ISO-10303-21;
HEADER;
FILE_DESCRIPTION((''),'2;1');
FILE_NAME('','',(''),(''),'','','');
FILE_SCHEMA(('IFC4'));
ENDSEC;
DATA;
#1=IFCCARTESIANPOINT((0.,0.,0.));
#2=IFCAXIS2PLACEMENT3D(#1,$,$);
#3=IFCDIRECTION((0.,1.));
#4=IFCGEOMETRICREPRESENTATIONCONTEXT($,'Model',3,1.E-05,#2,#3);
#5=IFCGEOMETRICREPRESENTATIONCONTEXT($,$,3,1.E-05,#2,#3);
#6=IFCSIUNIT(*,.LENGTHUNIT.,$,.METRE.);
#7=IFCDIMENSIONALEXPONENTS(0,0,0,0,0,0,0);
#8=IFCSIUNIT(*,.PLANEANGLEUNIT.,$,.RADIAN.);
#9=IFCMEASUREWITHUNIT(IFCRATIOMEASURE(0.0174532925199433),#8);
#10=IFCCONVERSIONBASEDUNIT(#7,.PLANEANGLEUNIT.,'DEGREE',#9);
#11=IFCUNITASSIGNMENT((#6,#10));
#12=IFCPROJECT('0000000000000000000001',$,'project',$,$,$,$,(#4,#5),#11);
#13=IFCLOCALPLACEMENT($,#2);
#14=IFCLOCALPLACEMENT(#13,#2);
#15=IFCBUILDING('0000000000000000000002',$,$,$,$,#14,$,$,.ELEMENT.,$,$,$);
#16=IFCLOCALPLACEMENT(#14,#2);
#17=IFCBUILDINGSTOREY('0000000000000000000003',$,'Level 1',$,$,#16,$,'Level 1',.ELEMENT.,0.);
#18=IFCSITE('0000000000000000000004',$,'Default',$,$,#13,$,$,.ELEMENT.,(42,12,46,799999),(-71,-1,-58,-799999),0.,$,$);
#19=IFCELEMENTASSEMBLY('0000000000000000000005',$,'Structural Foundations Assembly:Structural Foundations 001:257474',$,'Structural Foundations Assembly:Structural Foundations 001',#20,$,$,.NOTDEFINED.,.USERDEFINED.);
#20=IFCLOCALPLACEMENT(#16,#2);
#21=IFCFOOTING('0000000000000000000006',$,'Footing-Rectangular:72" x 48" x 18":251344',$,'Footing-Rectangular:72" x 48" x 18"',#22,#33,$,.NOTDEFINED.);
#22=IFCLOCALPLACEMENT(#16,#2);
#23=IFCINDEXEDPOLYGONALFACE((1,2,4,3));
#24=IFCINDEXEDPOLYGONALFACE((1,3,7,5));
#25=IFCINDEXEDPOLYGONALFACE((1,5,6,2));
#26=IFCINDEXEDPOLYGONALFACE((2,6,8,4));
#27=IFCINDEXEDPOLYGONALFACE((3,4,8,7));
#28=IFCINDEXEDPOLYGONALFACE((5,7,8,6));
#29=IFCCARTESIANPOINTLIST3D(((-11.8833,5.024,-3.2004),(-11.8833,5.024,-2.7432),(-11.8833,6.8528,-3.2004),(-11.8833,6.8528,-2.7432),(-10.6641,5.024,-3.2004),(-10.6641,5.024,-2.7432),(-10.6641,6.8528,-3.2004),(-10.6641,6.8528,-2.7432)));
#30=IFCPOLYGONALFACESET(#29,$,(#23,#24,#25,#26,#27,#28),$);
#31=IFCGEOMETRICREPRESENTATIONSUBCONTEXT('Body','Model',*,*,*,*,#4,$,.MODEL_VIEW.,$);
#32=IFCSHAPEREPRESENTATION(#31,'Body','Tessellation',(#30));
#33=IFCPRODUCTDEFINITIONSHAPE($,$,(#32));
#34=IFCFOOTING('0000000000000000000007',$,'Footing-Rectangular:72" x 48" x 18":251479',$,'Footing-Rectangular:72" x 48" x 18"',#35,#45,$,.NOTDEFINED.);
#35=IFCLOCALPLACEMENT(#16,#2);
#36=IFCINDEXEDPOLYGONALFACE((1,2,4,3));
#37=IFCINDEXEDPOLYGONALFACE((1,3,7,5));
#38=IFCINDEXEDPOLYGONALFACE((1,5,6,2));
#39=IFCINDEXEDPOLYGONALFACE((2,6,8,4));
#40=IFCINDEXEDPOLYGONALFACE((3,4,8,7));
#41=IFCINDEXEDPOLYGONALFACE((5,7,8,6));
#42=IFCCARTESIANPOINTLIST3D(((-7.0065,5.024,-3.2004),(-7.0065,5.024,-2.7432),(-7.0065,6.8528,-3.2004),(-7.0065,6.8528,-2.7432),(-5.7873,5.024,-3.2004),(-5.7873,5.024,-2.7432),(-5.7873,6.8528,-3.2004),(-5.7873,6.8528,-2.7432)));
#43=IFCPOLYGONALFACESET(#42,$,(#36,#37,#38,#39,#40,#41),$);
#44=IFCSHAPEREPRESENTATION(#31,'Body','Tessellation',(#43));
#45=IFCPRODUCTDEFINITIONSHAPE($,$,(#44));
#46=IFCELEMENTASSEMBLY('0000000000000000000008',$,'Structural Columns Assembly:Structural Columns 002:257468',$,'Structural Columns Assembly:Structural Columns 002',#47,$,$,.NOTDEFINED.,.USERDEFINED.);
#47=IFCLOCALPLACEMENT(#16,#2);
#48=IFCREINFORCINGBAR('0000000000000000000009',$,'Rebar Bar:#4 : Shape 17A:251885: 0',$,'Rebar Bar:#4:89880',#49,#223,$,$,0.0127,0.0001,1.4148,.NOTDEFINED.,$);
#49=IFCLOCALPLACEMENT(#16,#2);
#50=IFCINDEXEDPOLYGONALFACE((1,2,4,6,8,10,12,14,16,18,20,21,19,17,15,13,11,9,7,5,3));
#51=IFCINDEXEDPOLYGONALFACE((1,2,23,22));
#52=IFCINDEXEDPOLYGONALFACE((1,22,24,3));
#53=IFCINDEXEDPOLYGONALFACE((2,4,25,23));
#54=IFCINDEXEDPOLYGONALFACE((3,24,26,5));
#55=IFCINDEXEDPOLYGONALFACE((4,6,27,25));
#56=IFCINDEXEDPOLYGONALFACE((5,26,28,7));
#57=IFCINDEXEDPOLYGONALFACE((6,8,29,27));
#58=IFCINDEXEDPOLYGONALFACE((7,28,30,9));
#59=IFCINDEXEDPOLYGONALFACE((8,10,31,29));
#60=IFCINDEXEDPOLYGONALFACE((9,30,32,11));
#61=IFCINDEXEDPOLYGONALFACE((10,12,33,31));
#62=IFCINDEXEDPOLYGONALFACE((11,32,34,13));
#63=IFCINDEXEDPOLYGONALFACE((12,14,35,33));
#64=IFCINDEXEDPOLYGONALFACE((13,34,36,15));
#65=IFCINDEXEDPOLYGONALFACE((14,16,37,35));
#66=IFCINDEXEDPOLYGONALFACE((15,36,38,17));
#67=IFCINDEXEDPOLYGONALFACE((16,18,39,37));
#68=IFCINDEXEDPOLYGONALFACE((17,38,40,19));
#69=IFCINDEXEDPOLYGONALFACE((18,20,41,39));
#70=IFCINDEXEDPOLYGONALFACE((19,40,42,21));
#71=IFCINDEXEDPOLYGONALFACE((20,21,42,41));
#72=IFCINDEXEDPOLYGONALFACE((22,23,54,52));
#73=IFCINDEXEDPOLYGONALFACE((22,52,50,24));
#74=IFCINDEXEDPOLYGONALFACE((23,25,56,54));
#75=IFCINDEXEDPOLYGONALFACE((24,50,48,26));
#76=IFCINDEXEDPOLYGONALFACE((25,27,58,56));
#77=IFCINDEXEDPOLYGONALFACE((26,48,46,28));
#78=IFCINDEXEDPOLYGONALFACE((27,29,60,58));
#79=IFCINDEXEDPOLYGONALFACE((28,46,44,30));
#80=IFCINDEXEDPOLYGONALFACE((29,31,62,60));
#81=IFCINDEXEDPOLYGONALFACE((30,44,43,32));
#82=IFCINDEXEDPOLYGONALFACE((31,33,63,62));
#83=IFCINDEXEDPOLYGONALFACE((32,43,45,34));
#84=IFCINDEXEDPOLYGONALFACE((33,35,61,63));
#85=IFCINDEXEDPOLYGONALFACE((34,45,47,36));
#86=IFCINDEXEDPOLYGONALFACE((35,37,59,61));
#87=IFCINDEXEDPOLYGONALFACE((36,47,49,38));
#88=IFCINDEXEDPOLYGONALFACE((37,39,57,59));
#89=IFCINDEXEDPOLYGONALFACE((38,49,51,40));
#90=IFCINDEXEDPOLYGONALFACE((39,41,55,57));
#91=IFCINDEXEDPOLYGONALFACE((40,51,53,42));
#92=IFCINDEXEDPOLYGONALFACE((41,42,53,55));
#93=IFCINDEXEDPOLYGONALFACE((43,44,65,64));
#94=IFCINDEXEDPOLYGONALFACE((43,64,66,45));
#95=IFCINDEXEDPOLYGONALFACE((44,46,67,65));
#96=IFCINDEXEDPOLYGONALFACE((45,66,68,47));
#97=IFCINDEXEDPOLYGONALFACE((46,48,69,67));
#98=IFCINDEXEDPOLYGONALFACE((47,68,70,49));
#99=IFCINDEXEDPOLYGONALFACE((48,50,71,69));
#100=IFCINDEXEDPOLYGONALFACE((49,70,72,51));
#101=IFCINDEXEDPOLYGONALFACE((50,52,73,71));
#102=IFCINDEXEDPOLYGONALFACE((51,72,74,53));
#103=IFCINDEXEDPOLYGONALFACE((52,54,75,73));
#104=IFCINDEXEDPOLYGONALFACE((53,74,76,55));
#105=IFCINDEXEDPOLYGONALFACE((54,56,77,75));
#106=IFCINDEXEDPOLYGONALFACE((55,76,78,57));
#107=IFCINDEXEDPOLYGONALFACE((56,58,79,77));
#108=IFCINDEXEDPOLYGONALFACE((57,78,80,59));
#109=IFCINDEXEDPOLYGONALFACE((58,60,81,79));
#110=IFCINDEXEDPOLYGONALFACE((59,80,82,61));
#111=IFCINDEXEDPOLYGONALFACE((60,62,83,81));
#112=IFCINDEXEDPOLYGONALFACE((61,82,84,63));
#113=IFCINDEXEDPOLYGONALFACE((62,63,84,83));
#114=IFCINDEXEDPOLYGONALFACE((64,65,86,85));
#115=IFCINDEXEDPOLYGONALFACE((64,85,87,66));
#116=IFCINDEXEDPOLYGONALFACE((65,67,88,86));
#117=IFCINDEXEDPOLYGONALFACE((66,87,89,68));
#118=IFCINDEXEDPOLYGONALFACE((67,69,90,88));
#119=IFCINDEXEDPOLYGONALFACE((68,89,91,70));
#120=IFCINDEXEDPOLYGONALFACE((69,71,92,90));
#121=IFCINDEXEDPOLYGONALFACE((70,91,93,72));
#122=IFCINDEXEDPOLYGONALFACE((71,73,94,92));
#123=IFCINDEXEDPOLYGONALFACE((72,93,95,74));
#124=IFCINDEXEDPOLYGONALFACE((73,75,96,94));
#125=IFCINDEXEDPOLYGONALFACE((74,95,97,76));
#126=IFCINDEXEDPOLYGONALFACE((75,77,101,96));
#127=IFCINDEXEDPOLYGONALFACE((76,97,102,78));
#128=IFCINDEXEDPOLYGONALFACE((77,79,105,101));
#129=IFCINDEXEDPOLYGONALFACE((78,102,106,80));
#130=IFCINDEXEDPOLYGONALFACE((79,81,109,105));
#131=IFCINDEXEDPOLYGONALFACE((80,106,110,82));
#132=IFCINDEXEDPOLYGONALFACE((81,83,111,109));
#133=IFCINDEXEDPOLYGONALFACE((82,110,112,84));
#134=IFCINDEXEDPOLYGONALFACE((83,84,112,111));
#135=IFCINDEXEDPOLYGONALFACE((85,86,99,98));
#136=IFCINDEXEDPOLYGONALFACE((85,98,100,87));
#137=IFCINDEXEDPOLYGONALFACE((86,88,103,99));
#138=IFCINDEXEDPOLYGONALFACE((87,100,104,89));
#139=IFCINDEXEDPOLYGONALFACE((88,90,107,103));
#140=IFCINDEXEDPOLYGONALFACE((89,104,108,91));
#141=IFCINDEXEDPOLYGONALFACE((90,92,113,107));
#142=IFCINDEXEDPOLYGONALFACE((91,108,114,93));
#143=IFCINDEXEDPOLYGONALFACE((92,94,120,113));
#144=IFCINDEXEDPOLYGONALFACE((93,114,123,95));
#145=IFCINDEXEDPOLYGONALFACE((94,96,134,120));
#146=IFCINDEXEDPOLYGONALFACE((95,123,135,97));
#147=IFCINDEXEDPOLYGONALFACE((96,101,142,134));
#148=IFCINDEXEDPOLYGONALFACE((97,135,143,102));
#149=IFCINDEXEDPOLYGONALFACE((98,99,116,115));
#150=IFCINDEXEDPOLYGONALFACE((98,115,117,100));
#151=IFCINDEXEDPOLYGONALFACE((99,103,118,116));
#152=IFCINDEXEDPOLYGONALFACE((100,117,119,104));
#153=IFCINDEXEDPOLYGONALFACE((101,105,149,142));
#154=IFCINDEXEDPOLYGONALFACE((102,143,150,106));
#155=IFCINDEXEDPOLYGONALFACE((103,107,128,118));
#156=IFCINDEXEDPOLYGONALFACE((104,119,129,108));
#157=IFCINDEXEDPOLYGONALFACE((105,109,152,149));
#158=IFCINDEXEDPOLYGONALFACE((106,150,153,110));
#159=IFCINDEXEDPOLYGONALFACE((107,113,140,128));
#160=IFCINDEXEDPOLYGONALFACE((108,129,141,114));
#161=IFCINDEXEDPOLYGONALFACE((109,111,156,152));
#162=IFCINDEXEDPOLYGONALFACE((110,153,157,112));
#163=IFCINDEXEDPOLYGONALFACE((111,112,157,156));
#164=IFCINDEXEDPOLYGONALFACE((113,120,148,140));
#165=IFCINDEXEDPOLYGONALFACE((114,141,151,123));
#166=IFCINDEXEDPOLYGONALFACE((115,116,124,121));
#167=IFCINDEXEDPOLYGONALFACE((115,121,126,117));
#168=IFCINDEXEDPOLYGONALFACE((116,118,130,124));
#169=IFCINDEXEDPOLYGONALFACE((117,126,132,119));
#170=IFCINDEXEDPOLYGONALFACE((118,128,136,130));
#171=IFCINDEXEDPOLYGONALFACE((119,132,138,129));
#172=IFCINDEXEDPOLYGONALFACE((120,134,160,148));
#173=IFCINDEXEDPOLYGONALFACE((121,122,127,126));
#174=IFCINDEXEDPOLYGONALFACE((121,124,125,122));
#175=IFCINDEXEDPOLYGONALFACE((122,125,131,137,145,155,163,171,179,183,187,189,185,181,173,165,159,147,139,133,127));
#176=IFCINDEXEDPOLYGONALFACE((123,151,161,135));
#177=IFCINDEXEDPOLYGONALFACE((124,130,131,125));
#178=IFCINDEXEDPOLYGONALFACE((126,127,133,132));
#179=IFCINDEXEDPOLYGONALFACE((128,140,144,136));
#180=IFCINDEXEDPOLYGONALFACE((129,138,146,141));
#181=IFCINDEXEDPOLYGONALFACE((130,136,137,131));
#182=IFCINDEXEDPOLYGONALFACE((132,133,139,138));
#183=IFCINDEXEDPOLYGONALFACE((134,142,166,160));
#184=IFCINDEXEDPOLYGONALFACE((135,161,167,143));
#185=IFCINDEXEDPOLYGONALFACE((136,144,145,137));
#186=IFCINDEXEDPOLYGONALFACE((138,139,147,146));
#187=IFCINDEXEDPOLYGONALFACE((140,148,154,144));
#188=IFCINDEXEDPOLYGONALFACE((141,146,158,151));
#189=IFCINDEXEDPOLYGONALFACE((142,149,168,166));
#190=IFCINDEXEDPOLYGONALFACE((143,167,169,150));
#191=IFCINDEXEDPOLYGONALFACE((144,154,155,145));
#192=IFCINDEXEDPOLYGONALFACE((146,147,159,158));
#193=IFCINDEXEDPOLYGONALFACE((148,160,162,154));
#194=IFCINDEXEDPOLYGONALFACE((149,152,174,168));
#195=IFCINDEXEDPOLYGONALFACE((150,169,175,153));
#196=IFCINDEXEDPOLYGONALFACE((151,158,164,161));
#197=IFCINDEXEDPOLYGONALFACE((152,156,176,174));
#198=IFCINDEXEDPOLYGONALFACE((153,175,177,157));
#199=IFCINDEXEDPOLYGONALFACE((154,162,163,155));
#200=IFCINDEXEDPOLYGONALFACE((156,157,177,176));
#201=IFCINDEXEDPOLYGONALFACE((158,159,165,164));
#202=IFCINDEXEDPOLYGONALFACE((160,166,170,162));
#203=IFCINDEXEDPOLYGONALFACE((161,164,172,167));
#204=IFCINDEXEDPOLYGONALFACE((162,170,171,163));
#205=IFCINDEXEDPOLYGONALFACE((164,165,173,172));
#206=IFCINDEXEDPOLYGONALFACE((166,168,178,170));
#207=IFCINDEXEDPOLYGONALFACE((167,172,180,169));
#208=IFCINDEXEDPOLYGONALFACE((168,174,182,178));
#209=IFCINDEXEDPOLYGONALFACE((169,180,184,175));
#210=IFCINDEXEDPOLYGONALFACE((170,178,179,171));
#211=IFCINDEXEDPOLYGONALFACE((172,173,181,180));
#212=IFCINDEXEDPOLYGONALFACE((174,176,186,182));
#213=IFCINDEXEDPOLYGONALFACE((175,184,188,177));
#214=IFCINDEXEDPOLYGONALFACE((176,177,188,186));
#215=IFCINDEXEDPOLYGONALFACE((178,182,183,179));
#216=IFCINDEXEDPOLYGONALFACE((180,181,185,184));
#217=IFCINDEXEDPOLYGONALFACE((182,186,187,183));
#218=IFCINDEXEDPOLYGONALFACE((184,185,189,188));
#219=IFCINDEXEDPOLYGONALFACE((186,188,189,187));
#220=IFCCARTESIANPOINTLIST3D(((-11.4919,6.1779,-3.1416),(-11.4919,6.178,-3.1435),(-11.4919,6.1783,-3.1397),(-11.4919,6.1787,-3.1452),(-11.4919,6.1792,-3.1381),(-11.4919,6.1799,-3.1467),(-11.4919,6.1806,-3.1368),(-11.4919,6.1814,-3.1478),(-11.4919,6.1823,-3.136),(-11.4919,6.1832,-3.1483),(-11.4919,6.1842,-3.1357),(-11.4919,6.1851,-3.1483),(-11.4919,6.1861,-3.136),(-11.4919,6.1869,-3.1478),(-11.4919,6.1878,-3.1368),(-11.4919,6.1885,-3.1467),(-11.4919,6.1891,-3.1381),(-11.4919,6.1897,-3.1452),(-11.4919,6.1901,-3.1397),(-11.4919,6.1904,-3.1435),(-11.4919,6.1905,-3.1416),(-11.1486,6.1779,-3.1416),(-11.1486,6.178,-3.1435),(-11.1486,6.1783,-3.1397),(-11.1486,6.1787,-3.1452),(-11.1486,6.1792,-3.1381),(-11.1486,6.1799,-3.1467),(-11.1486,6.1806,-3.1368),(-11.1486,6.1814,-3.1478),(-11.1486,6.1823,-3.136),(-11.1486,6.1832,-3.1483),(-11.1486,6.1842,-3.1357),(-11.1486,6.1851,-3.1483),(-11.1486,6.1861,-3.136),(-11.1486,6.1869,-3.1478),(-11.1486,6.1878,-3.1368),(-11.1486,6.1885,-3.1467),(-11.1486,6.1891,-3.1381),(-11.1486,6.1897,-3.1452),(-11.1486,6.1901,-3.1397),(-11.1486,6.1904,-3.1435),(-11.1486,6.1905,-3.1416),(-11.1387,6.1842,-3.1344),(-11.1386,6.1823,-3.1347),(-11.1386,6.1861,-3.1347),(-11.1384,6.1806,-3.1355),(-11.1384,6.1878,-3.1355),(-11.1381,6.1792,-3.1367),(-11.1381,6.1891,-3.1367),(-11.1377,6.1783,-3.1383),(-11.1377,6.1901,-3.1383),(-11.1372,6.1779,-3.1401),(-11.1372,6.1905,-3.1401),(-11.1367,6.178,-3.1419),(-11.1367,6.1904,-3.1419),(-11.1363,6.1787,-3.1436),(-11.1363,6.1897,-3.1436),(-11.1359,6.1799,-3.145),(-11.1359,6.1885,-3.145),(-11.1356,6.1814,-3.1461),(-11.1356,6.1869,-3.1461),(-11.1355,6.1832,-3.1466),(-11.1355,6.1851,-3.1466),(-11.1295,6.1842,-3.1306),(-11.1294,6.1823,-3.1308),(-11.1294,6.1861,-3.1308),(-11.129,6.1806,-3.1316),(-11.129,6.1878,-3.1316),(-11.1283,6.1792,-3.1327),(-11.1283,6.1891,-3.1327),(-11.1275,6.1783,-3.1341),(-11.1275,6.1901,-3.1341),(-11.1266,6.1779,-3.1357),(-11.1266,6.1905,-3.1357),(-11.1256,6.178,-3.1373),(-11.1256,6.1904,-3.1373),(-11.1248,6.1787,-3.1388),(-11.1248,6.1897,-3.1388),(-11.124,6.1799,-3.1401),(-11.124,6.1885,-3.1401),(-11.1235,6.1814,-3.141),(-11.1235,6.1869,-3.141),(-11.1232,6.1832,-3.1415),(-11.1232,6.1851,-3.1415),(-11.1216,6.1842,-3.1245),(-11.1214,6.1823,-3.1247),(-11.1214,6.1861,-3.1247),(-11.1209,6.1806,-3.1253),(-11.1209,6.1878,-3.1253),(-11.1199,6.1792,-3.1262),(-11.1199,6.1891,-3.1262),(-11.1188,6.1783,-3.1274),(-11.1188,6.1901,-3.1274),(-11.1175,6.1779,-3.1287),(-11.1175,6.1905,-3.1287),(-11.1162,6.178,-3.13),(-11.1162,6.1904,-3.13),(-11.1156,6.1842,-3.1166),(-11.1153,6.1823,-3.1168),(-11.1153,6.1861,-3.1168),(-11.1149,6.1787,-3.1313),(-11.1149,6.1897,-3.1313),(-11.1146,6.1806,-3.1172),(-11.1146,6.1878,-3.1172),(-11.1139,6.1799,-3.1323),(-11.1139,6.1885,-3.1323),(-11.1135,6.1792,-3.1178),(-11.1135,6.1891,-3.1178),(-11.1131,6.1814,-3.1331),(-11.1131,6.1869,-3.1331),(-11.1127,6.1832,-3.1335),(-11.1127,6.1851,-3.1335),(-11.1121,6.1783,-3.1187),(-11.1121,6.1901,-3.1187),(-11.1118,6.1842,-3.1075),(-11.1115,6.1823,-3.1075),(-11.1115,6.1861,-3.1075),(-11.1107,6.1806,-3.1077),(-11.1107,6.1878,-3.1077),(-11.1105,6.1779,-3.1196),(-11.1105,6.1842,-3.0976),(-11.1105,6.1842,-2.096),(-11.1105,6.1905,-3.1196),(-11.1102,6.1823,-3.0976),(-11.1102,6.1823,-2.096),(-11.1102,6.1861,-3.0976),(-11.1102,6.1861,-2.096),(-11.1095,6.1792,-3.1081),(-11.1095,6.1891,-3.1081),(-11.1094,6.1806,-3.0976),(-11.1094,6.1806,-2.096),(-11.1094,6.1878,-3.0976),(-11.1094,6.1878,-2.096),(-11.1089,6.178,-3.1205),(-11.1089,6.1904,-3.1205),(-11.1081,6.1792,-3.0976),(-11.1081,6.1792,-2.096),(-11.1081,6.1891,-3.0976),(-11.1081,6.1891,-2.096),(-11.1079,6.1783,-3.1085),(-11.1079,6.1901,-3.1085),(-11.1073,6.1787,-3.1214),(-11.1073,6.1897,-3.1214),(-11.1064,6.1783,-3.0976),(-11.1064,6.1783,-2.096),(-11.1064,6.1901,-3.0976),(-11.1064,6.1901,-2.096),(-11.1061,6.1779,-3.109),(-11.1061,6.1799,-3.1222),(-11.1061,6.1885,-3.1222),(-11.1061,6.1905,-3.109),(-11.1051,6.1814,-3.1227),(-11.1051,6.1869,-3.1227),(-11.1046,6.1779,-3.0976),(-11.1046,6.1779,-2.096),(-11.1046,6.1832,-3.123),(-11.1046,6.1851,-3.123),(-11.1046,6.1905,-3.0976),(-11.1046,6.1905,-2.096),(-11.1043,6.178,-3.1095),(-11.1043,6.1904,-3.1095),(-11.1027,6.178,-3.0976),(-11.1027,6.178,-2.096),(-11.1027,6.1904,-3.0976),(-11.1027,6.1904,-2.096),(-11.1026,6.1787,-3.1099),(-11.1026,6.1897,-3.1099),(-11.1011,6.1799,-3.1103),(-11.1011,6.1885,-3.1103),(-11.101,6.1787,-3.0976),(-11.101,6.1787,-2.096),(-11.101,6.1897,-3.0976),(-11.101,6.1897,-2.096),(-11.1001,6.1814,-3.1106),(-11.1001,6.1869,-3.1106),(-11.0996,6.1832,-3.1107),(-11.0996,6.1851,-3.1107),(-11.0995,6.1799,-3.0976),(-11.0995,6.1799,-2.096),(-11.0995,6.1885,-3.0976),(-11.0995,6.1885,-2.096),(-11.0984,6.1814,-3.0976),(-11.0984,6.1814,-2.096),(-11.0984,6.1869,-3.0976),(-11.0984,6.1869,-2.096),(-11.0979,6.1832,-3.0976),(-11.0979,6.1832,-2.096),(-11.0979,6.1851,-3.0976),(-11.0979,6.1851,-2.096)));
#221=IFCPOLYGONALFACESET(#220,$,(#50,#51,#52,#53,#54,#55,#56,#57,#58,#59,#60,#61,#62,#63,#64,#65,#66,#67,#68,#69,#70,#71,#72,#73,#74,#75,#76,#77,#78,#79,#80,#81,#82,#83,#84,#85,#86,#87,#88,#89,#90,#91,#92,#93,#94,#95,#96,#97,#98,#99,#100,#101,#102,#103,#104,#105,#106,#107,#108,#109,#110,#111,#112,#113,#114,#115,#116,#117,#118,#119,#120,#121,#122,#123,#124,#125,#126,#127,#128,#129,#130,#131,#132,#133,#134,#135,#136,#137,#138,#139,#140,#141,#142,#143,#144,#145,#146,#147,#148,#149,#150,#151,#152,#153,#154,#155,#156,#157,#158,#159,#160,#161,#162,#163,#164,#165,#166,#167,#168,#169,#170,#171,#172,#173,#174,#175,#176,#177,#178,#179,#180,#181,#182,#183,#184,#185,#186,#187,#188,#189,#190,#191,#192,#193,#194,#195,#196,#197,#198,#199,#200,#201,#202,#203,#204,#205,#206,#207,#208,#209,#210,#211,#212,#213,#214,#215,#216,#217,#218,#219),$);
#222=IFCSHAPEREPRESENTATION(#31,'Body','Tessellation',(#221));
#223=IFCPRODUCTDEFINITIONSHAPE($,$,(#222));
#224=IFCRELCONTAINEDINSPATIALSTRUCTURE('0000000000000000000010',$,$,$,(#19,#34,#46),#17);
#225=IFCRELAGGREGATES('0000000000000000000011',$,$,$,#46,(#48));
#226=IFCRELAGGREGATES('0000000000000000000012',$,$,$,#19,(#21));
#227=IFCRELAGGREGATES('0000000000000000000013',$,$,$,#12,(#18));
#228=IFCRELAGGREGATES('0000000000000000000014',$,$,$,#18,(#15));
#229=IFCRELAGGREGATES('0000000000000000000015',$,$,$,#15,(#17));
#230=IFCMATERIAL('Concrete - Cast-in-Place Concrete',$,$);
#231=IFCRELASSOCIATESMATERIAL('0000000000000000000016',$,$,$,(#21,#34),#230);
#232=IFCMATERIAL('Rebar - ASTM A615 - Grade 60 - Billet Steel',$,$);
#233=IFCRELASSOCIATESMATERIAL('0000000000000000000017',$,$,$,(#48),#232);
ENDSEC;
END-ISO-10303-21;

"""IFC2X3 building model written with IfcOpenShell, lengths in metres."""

from ifc_helpers import new_model, entity, si_unit, converted_unit, direction, frame, origin, origin_2d_with_axis, place, context, subcontext, project, spatial, rectangle, extrude, material, element, aggregate, save


model = new_model("IFC2X3")

# Units and contexts
model_context = context("Model", 3, precision=1e-05, world=origin(), true_north=direction((0.0, 1.0)))
context_of_model = context(None, 3, precision=1e-05, world=origin(), true_north=direction((0.0, 1.0)))
body_context = subcontext(model_context, "Body", "Model", "MODEL_VIEW")
ifc_project = project(units=[si_unit("LENGTHUNIT", "METRE"), converted_unit("PLANEANGLEUNIT", "DEGREE", entity("IfcRatioMeasure", 0.0174532925199433), si_unit("PLANEANGLEUNIT", "RADIAN"), dimensions=[0, 0, 0, 0, 0, 0, 0])], contexts=[model_context, context_of_model])

# Site, building, storey
site_placement = place(None, origin())
site = spatial("IfcSite", under=ifc_project, at=site_placement, Name="Default", CompositionType="ELEMENT", RefLatitude=(42, 12, 46, 799999), RefLongitude=(-71, -1, -58, -799999), RefElevation=0.0)
building_placement = place(site_placement, origin())
building = spatial("IfcBuilding", under=site, at=building_placement, CompositionType="ELEMENT")
storey_placement = place(building_placement, origin())
storey = spatial("IfcBuildingStorey", under=building, at=storey_placement, Name="Level 1", LongName="Level 1", CompositionType="ELEMENT", Elevation=0.0)

# Element assembly, footing
assembly_1_placement = place(storey_placement, origin())
assembly_1 = element("IfcElementAssembly", 1, at=assembly_1_placement, inside=storey, Name="Structural Foundations Assembly:Structural Foundations 001:257474", ObjectType="Structural Foundations Assembly:Structural Foundations 001", AssemblyPlace="NOTDEFINED", PredefinedType="USERDEFINED")
ifc_material_1 = material(Name="Concrete - Cast-in-Place Concrete")
footing_1_placement = place(assembly_1_placement, origin())
footing_1 = element("IfcFooting", 2, at=footing_1_placement, material=ifc_material_1, Name="Footing-Rectangular:72\" x 48\" x 18\":251344", ObjectType="Footing-Rectangular:72\" x 48\" x 18\"", PredefinedType="NOTDEFINED", context=body_context, shape_type="SweptSolid", body=[
    extrude(rectangle(XDim=1.2192, YDim=1.8288, at=origin_2d_with_axis()), frame((-11.2737, 5.9384, -3.2004), z_axis=(0.0, 0.0, 1.0), x_axis=(-1.0, 0.0, 0.0)), (0.0, 0.0, 1.0), 0.4572),
])

# Footing
footing_2_placement = place(storey_placement, origin())
element("IfcFooting", 3, at=footing_2_placement, inside=storey, material=ifc_material_1, Name="Footing-Rectangular:72\" x 48\" x 18\":251479", ObjectType="Footing-Rectangular:72\" x 48\" x 18\"", PredefinedType="NOTDEFINED", context=body_context, shape_type="SweptSolid", body=[
    extrude(rectangle(XDim=1.2192, YDim=1.8288, at=origin_2d_with_axis()), frame((-6.3969, 5.9384, -3.2004), z_axis=(0.0, 0.0, 1.0), x_axis=(-1.0, 0.0, 0.0)), (0.0, 0.0, 1.0), 0.4572),
])

# Element assembly, reinforcing bar
assembly_2_placement = place(storey_placement, origin())
assembly_2 = element("IfcElementAssembly", 4, at=assembly_2_placement, inside=storey, Name="Structural Columns Assembly:Structural Columns 002:257468", ObjectType="Structural Columns Assembly:Structural Columns 002", AssemblyPlace="NOTDEFINED", PredefinedType="USERDEFINED")
ifc_material_2 = material(Name="Rebar - ASTM A615 - Grade 60 - Billet Steel")
reinforcing_bar_1_placement = place(assembly_2_placement, origin())
reinforcing_bar_1 = element("IfcReinforcingBar", 5, at=reinforcing_bar_1_placement, material=ifc_material_2, Name="Rebar Bar:#4 : Shape 17A:251885: 0", ObjectType="Rebar Bar:#4:89880", BarLength=1.4148, BarRole="NOTDEFINED", CrossSectionArea=0.0001, NominalDiameter=0.0127, context=body_context, shape_type="AdvancedSweptSolid", body=[
    entity("IfcSweptDiskSolid", entity("IfcCompositeCurve", [entity("IfcCompositeCurveSegment", "CONTINUOUS", True, entity("IfcPolyline", [entity("IfcCartesianPoint", [-11.4919, 6.1842, -3.142]), entity("IfcCartesianPoint", [-11.1486, 6.1842, -3.142])])), entity("IfcCompositeCurveSegment", "CONTINUOUS", True, entity("IfcTrimmedCurve", entity("IfcCircle", entity("IfcAxis2Placement3D", entity("IfcCartesianPoint", [-11.1486, 6.1842, -3.0976]), entity("IfcDirection", [0.0, -1.0, 0.0]), entity("IfcDirection", [1.0, 0.0, 0.0])), 0.0445), [entity("IfcParameterValue", 270.0)], [entity("IfcParameterValue", 360.0)], True, "PARAMETER")), entity("IfcCompositeCurveSegment", "CONTINUOUS", True, entity("IfcPolyline", [entity("IfcCartesianPoint", [-11.1041, 6.1842, -3.0976]), entity("IfcCartesianPoint", [-11.1041, 6.1842, -2.096])]))], False), 0.0063, None, 0.0, 92.0),
])
aggregate(assembly_2, [reinforcing_bar_1])

aggregate(assembly_1, [footing_1])

save(model, "model.ifc")
